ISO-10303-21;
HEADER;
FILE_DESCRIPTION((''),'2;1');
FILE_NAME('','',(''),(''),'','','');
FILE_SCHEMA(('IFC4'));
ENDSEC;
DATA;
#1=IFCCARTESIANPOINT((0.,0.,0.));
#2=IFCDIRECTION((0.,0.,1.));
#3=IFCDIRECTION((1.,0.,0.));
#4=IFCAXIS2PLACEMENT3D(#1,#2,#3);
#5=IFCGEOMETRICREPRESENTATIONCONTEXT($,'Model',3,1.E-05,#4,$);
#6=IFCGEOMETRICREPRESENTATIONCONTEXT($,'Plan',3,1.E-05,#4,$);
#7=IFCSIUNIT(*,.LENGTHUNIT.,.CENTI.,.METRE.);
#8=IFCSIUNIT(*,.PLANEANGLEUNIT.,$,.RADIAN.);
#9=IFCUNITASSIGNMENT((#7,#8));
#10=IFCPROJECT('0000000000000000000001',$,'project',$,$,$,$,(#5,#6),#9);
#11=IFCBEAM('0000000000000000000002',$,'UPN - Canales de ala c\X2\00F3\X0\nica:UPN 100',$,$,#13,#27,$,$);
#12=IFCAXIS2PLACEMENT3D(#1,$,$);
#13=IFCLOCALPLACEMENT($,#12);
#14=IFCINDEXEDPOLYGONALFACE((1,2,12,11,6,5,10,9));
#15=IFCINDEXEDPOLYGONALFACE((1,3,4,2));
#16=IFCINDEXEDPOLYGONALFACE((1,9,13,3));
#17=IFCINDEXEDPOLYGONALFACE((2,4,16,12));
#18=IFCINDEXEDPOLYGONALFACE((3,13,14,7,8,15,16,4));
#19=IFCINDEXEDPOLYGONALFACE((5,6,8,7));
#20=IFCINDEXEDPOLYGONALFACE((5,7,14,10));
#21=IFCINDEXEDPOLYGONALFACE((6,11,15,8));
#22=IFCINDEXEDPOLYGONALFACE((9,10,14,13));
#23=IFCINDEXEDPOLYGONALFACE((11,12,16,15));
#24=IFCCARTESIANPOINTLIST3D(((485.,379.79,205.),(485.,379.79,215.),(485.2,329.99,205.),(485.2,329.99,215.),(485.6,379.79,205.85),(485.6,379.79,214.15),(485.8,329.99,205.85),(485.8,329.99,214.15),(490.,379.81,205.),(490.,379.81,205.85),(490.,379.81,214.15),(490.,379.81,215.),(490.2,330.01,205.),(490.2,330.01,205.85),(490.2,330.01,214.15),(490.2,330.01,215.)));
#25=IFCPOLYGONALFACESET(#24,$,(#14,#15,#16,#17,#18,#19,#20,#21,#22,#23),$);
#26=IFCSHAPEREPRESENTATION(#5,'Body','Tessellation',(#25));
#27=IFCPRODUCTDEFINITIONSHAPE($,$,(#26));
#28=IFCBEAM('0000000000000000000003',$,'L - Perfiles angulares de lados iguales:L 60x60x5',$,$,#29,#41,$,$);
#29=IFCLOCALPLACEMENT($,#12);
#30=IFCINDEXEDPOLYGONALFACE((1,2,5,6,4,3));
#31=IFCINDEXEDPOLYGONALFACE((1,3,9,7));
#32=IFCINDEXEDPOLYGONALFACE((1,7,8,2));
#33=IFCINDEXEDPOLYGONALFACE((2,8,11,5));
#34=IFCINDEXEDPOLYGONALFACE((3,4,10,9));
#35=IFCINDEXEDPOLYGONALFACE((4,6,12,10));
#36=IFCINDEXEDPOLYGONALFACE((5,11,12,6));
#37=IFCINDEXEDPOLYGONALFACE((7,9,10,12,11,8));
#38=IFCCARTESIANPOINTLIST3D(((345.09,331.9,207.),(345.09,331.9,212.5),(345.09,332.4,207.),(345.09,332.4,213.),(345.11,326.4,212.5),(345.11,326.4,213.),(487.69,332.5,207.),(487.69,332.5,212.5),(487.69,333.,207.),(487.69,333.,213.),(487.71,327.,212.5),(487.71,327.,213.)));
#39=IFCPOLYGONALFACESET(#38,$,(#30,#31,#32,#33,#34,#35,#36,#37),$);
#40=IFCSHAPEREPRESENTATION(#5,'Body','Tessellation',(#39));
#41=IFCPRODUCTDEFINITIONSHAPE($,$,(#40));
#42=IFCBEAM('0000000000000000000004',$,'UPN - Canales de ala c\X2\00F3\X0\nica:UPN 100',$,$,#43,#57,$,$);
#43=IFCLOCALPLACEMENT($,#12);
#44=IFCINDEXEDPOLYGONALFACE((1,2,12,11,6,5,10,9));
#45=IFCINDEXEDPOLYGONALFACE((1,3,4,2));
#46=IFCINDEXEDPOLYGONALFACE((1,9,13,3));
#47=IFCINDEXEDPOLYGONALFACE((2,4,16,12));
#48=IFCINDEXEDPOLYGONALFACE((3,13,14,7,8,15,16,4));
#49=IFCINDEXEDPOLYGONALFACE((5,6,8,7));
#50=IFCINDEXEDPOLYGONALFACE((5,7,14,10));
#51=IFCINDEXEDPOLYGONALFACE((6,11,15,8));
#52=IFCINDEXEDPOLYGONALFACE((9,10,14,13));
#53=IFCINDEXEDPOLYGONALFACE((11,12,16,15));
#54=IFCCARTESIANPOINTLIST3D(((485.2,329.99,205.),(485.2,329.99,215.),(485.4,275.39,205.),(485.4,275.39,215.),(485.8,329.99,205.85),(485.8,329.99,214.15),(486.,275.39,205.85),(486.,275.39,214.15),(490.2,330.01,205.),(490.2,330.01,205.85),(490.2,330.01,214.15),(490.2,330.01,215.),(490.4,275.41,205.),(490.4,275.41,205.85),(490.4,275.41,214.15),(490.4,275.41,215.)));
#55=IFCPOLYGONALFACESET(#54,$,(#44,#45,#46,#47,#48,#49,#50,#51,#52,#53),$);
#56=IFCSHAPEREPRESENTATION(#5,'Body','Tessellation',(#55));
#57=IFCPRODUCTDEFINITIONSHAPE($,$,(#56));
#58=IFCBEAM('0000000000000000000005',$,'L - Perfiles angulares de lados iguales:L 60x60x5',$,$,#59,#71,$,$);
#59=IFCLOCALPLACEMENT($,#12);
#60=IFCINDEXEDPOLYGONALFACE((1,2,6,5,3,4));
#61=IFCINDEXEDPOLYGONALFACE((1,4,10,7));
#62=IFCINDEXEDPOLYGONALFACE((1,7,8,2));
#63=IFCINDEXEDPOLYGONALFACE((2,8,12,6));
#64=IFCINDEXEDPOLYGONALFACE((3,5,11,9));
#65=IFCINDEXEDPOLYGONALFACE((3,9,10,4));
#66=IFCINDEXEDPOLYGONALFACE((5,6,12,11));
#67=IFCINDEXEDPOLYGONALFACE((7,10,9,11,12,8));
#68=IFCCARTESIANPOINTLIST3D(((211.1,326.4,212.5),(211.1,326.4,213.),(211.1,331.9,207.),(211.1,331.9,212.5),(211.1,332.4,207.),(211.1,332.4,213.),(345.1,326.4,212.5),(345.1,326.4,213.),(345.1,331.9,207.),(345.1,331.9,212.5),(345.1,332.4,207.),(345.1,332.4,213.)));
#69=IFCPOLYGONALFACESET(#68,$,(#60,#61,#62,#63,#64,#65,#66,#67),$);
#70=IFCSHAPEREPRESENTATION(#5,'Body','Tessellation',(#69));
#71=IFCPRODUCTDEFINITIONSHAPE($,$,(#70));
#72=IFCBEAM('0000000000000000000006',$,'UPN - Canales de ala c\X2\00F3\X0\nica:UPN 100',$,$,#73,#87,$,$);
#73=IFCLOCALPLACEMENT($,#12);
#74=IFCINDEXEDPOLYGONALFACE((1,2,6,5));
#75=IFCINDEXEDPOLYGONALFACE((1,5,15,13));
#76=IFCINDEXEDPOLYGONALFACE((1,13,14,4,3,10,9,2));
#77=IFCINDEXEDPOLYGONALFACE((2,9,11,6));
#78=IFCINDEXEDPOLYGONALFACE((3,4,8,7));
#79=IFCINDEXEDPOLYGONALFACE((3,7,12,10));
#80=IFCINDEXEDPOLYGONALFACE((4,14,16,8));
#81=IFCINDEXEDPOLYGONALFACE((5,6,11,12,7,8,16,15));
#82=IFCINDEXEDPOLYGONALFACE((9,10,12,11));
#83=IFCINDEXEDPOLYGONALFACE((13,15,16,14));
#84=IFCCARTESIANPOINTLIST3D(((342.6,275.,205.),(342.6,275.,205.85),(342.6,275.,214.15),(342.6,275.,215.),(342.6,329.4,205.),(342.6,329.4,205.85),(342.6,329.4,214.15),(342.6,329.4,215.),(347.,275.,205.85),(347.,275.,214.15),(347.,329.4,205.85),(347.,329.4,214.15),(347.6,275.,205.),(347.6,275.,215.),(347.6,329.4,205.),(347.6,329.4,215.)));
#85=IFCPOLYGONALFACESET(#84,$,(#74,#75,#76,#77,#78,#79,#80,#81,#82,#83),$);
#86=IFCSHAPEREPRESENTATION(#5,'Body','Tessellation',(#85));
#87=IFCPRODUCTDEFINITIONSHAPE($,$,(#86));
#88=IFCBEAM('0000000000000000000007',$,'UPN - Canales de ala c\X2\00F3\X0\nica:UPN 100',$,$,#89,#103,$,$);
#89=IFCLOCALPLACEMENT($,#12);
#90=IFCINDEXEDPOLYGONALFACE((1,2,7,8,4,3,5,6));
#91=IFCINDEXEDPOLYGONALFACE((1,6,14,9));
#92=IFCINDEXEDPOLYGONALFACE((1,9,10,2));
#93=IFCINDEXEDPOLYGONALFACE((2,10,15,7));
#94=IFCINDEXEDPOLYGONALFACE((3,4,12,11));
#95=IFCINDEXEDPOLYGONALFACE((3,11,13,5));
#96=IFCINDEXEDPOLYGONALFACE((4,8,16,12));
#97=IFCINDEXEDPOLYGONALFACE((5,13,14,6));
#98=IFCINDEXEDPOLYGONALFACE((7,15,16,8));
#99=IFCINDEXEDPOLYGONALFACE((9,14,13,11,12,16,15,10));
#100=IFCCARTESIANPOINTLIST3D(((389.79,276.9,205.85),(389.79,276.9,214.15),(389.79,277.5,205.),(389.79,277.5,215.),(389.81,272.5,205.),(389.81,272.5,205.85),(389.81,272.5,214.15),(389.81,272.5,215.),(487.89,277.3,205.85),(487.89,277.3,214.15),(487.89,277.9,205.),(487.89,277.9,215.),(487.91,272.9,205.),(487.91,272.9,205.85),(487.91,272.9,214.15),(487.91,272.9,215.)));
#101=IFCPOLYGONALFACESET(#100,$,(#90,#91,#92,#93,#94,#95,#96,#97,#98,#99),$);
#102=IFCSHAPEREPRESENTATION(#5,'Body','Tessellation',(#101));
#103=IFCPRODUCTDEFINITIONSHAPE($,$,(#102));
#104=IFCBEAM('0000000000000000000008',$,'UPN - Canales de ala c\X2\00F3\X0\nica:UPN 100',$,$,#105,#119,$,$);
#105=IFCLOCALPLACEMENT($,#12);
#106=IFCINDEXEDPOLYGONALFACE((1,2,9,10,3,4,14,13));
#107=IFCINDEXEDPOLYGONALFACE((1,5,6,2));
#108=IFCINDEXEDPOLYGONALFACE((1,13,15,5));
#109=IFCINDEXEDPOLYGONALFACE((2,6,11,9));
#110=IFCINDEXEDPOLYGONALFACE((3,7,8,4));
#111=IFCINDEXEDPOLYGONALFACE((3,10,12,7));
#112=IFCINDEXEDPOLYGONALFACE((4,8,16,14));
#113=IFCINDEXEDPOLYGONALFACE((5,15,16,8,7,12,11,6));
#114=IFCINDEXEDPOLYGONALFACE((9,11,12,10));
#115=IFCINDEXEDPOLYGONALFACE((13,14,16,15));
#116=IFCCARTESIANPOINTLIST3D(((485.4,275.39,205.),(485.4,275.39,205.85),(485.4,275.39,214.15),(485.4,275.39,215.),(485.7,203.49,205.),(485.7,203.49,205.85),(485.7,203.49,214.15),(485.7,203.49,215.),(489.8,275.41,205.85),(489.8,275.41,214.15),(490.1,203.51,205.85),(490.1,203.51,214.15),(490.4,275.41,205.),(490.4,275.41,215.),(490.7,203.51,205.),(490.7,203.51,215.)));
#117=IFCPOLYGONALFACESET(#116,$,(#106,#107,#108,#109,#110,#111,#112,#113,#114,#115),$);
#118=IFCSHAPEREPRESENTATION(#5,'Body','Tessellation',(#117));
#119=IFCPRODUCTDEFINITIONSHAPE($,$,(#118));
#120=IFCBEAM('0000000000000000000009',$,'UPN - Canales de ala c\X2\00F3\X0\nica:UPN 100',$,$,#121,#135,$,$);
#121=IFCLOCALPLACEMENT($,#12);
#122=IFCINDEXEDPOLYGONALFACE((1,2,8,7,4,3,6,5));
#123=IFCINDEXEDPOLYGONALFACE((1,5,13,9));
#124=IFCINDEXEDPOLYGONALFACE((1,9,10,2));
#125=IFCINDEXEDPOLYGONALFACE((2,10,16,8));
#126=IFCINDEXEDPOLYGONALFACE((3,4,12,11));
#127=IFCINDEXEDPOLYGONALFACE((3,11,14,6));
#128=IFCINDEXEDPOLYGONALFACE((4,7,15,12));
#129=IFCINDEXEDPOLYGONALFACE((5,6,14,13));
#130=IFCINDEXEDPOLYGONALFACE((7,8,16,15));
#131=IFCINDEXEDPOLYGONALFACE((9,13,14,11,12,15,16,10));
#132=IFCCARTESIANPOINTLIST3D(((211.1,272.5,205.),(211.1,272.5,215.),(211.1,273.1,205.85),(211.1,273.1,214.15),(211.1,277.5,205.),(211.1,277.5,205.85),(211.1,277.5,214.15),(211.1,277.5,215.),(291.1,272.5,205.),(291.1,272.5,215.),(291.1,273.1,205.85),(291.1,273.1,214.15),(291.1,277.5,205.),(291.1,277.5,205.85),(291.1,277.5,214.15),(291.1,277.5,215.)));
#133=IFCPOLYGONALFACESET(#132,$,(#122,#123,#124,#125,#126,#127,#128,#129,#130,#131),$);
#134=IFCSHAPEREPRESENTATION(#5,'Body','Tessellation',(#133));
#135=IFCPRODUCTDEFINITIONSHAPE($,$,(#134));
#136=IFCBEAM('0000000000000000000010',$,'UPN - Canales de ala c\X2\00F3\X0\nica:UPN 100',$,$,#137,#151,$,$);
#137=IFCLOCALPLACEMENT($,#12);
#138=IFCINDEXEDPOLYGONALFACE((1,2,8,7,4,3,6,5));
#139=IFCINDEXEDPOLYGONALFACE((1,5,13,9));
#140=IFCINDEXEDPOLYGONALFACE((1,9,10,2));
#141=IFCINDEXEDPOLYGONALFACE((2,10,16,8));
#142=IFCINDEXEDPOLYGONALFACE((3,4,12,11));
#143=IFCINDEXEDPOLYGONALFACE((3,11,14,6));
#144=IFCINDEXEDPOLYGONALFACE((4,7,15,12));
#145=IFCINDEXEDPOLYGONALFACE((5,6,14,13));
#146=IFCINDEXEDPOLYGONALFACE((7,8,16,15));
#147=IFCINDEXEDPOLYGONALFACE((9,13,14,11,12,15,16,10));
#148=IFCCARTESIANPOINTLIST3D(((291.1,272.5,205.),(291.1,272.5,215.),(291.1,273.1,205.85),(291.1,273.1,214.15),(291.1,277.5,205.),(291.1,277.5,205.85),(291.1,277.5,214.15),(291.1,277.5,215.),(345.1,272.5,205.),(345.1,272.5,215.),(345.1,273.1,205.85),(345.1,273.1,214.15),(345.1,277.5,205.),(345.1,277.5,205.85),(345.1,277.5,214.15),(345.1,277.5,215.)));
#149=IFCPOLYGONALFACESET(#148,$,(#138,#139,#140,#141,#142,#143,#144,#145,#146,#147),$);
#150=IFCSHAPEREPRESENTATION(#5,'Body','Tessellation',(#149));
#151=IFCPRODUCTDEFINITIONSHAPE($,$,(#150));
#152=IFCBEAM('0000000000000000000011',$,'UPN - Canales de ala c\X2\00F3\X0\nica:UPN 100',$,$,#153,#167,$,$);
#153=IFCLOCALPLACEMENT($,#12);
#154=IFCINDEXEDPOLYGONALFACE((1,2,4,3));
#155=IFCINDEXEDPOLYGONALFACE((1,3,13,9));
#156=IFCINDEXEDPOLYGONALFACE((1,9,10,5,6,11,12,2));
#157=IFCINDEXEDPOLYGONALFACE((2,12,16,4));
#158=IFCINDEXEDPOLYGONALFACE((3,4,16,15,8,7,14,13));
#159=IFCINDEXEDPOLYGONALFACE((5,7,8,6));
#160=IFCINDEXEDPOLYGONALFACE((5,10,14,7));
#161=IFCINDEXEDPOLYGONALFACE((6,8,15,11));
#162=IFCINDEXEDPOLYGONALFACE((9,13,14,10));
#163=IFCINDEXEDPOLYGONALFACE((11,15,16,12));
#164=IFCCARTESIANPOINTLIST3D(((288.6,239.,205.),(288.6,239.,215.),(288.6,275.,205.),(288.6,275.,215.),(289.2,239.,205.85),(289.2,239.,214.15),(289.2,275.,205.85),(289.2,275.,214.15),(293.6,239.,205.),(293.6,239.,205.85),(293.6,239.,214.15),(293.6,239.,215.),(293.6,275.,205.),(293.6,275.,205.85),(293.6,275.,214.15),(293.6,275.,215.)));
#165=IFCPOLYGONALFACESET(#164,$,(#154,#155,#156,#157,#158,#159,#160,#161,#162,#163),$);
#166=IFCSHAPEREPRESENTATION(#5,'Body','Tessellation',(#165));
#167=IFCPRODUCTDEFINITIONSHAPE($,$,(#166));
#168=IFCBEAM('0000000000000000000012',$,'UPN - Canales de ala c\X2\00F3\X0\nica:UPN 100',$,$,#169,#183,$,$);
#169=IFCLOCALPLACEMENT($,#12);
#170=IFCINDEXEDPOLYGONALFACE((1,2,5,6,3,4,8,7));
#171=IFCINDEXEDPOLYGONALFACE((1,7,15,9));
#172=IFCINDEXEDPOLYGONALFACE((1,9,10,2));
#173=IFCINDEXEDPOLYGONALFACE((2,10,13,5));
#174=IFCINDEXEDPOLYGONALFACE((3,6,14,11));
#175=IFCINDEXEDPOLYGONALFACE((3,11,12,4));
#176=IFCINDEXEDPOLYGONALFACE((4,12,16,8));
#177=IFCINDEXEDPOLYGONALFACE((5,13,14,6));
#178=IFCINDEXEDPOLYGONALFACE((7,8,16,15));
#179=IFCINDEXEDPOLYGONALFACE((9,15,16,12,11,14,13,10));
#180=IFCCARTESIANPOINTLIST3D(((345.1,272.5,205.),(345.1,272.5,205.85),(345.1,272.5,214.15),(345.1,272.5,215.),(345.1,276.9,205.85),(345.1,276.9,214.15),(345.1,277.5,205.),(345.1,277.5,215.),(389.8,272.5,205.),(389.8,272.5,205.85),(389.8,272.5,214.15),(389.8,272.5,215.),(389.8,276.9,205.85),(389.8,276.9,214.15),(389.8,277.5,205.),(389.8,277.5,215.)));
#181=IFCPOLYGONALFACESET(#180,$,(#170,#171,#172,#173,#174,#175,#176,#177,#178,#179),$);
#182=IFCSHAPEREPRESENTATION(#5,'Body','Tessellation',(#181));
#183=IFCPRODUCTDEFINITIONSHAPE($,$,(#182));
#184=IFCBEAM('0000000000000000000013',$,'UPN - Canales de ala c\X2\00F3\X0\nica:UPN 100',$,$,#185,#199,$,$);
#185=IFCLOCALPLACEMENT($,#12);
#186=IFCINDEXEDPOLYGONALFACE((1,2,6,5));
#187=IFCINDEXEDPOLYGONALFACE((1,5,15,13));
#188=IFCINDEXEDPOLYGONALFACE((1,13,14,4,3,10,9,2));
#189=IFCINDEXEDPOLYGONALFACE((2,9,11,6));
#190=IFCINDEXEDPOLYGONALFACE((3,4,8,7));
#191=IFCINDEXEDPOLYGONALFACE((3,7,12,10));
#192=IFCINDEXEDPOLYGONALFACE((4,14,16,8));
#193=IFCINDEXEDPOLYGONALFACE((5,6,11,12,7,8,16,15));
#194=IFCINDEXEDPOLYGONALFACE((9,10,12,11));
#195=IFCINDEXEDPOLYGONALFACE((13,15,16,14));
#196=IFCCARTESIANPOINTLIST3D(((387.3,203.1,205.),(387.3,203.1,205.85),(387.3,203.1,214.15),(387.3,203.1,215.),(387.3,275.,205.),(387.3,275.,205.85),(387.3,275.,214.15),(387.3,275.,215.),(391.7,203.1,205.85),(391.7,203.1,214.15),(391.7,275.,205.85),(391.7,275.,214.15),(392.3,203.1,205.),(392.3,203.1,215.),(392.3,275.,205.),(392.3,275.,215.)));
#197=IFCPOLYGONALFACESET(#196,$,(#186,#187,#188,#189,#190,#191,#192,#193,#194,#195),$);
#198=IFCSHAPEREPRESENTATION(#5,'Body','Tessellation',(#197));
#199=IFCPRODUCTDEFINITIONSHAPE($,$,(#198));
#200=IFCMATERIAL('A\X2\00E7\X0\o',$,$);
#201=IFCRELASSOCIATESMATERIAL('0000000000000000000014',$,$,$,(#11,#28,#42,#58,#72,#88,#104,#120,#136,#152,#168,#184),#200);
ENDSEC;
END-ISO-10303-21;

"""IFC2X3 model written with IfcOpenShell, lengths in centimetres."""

from ifc_helpers import new_model, si_unit, frame, frame_2d, origin_with_axes, origin_2d_with_axis, place, context, project, polyline, u_section, outline, extrude, material, element, save


model = new_model("IFC2X3")

# Units and contexts
model_context = context("Model", 3, precision=1e-05, world=origin_with_axes())
plan_context = context("Plan", 3, precision=1e-05, world=origin_with_axes())
ifc_project = project(units=[si_unit("LENGTHUNIT", "METRE", prefix="CENTI"), si_unit("PLANEANGLEUNIT", "RADIAN")], contexts=[model_context, plan_context])

# Shared definitions
ifc_material = material(Name="Aço")

# Beams
beam_1_placement = place(None, frame((487.7, 330.0, 210.0), z_axis=(-0.004016, 0.999992, 0.0), x_axis=(0.999992, 0.004016, 0.0)))
element("IfcBeam", 1, at=beam_1_placement, material=ifc_material, Name="UPN - Canales de ala cónica:UPN 100", context=model_context, shape_type="SweptSolid", body=[
    extrude(u_section(Depth=10.0, FlangeWidth=5.0, WebThickness=0.6, FlangeThickness=0.85, FilletRadius=0.0, EdgeRadius=0.0, FlangeSlope=0.0, CentreOfGravityInX=0.0, at=frame_2d((0.0, 0.0), x_axis=(1.0, 0.0))), origin_with_axes(), (0.0, 0.0, 1.0), 49.8),
])
beam_2_placement = place(None, frame((345.1, 329.4, 210.0), z_axis=(0.999991, 0.004208, 0.0), x_axis=(-0.004208, 0.999991, 0.0)))
element("IfcBeam", 2, at=beam_2_placement, material=ifc_material, Name="L - Perfiles angulares de lados iguales:L 60x60x5", context=model_context, shape_type="SweptSolid", body=[
    extrude(outline(polyline([(3.0, -3.0), (3.0, 3.0), (-3.0, 3.0), (-3.0, 2.5), (2.5, 2.5), (2.5, -3.0), (3.0, -3.0)])), origin_with_axes(), (0.0, 0.0, 1.0), 142.6),
])
beam_3_placement = place(None, frame((487.9, 275.4, 210.0), z_axis=(-0.003663, 0.999993, 0.0), x_axis=(0.999993, 0.003663, 0.0)))
element("IfcBeam", 3, at=beam_3_placement, material=ifc_material, Name="UPN - Canales de ala cónica:UPN 100", context=model_context, shape_type="SweptSolid", body=[
    extrude(u_section(Depth=10.0, FlangeWidth=5.0, WebThickness=0.6, FlangeThickness=0.85, FilletRadius=0.0, EdgeRadius=0.0, FlangeSlope=0.0, CentreOfGravityInX=0.0, at=frame_2d((0.0, 0.0), x_axis=(1.0, 0.0))), origin_with_axes(), (0.0, 0.0, 1.0), 54.6),
])
beam_4_placement = place(None, frame((345.1, 329.4, 210.0), z_axis=(-1.0, 0.0, 0.0), x_axis=(0.0, 0.0, 1.0)))
element("IfcBeam", 4, at=beam_4_placement, material=ifc_material, Name="L - Perfiles angulares de lados iguales:L 60x60x5", context=model_context, shape_type="SweptSolid", body=[
    extrude(outline(polyline([(3.0, -3.0), (3.0, 3.0), (-3.0, 3.0), (-3.0, 2.5), (2.5, 2.5), (2.5, -3.0), (3.0, -3.0)])), origin_with_axes(), (0.0, 0.0, 1.0), 134.0),
])
beam_5_placement = place(None, frame((345.1, 275.0, 210.0), z_axis=(0.0, 1.0, 0.0), x_axis=(-1.0, 0.0, 0.0)))
element("IfcBeam", 5, at=beam_5_placement, material=ifc_material, Name="UPN - Canales de ala cónica:UPN 100", context=model_context, shape_type="SweptSolid", body=[
    extrude(u_section(Depth=10.0, FlangeWidth=5.0, WebThickness=0.6, FlangeThickness=0.85, FilletRadius=0.0, EdgeRadius=0.0, FlangeSlope=0.0, CentreOfGravityInX=0.0, at=origin_2d_with_axis()), origin_with_axes(), (0.0, 0.0, 1.0), 54.4),
])
beam_6_placement = place(None, frame((389.8, 275.0, 210.0), z_axis=(0.999992, 0.004077, 0.0), x_axis=(0.004077, -0.999992, 0.0)))
element("IfcBeam", 6, at=beam_6_placement, material=ifc_material, Name="UPN - Canales de ala cónica:UPN 100", context=model_context, shape_type="SweptSolid", body=[
    extrude(u_section(Depth=10.0, FlangeWidth=5.0, WebThickness=0.6, FlangeThickness=0.85, FilletRadius=0.0, EdgeRadius=0.0, FlangeSlope=0.0, CentreOfGravityInX=0.0, at=frame_2d((0.0, 0.0), x_axis=(1.0, 0.0))), origin_with_axes(), (0.0, 0.0, 1.0), 98.1),
])
beam_7_placement = place(None, frame((488.2, 203.5, 210.0), z_axis=(-0.004173, 0.999991, 0.0), x_axis=(-0.999991, -0.004173, 0.0)))
element("IfcBeam", 7, at=beam_7_placement, material=ifc_material, Name="UPN - Canales de ala cónica:UPN 100", context=model_context, shape_type="SweptSolid", body=[
    extrude(u_section(Depth=10.0, FlangeWidth=5.0, WebThickness=0.6, FlangeThickness=0.85, FilletRadius=0.0, EdgeRadius=0.0, FlangeSlope=0.0, CentreOfGravityInX=0.0, at=frame_2d((0.0, 0.0), x_axis=(1.0, 0.0))), origin_with_axes(), (0.0, 0.0, 1.0), 71.9),
])
beam_8_placement = place(None, frame((291.1, 275.0, 210.0), z_axis=(-1.0, 0.0, 0.0), x_axis=(0.0, 1.0, 0.0)))
element("IfcBeam", 8, at=beam_8_placement, material=ifc_material, Name="UPN - Canales de ala cónica:UPN 100", context=model_context, shape_type="SweptSolid", body=[
    extrude(u_section(Depth=10.0, FlangeWidth=5.0, WebThickness=0.6, FlangeThickness=0.85, FilletRadius=0.0, EdgeRadius=0.0, FlangeSlope=0.0, CentreOfGravityInX=0.0, at=origin_2d_with_axis()), origin_with_axes(), (0.0, 0.0, 1.0), 80.0),
])
beam_9_placement = place(None, frame((345.1, 275.0, 210.0), z_axis=(-1.0, 0.0, 0.0), x_axis=(0.0, 1.0, 0.0)))
element("IfcBeam", 9, at=beam_9_placement, material=ifc_material, Name="UPN - Canales de ala cónica:UPN 100", context=model_context, shape_type="SweptSolid", body=[
    extrude(u_section(Depth=10.0, FlangeWidth=5.0, WebThickness=0.6, FlangeThickness=0.85, FilletRadius=0.0, EdgeRadius=0.0, FlangeSlope=0.0, CentreOfGravityInX=0.0, at=origin_2d_with_axis()), origin_with_axes(), (0.0, 0.0, 1.0), 54.0),
])
beam_10_placement = place(None, frame((291.1, 239.0, 210.0), z_axis=(0.0, 1.0, 0.0), x_axis=(1.0, 0.0, 0.0)))
element("IfcBeam", 10, at=beam_10_placement, material=ifc_material, Name="UPN - Canales de ala cónica:UPN 100", context=model_context, shape_type="SweptSolid", body=[
    extrude(u_section(Depth=10.0, FlangeWidth=5.0, WebThickness=0.6, FlangeThickness=0.85, FilletRadius=0.0, EdgeRadius=0.0, FlangeSlope=0.0, CentreOfGravityInX=0.0, at=origin_2d_with_axis()), origin_with_axes(), (0.0, 0.0, 1.0), 36.0),
])
beam_11_placement = place(None, frame((389.8, 275.0, 210.0), z_axis=(-1.0, 0.0, 0.0), x_axis=(0.0, -1.0, 0.0)))
element("IfcBeam", 11, at=beam_11_placement, material=ifc_material, Name="UPN - Canales de ala cónica:UPN 100", context=model_context, shape_type="SweptSolid", body=[
    extrude(u_section(Depth=10.0, FlangeWidth=5.0, WebThickness=0.6, FlangeThickness=0.85, FilletRadius=0.0, EdgeRadius=0.0, FlangeSlope=0.0, CentreOfGravityInX=0.0, at=origin_2d_with_axis()), origin_with_axes(), (0.0, 0.0, 1.0), 44.7),
])
beam_12_placement = place(None, frame((389.8, 203.1, 210.0), z_axis=(0.0, 1.0, 0.0), x_axis=(-1.0, 0.0, 0.0)))
element("IfcBeam", 12, at=beam_12_placement, material=ifc_material, Name="UPN - Canales de ala cónica:UPN 100", context=model_context, shape_type="SweptSolid", body=[
    extrude(u_section(Depth=10.0, FlangeWidth=5.0, WebThickness=0.6, FlangeThickness=0.85, FilletRadius=0.0, EdgeRadius=0.0, FlangeSlope=0.0, CentreOfGravityInX=0.0, at=origin_2d_with_axis()), origin_with_axes(), (0.0, 0.0, 1.0), 71.9),
])

save(model, "model.ifc")
